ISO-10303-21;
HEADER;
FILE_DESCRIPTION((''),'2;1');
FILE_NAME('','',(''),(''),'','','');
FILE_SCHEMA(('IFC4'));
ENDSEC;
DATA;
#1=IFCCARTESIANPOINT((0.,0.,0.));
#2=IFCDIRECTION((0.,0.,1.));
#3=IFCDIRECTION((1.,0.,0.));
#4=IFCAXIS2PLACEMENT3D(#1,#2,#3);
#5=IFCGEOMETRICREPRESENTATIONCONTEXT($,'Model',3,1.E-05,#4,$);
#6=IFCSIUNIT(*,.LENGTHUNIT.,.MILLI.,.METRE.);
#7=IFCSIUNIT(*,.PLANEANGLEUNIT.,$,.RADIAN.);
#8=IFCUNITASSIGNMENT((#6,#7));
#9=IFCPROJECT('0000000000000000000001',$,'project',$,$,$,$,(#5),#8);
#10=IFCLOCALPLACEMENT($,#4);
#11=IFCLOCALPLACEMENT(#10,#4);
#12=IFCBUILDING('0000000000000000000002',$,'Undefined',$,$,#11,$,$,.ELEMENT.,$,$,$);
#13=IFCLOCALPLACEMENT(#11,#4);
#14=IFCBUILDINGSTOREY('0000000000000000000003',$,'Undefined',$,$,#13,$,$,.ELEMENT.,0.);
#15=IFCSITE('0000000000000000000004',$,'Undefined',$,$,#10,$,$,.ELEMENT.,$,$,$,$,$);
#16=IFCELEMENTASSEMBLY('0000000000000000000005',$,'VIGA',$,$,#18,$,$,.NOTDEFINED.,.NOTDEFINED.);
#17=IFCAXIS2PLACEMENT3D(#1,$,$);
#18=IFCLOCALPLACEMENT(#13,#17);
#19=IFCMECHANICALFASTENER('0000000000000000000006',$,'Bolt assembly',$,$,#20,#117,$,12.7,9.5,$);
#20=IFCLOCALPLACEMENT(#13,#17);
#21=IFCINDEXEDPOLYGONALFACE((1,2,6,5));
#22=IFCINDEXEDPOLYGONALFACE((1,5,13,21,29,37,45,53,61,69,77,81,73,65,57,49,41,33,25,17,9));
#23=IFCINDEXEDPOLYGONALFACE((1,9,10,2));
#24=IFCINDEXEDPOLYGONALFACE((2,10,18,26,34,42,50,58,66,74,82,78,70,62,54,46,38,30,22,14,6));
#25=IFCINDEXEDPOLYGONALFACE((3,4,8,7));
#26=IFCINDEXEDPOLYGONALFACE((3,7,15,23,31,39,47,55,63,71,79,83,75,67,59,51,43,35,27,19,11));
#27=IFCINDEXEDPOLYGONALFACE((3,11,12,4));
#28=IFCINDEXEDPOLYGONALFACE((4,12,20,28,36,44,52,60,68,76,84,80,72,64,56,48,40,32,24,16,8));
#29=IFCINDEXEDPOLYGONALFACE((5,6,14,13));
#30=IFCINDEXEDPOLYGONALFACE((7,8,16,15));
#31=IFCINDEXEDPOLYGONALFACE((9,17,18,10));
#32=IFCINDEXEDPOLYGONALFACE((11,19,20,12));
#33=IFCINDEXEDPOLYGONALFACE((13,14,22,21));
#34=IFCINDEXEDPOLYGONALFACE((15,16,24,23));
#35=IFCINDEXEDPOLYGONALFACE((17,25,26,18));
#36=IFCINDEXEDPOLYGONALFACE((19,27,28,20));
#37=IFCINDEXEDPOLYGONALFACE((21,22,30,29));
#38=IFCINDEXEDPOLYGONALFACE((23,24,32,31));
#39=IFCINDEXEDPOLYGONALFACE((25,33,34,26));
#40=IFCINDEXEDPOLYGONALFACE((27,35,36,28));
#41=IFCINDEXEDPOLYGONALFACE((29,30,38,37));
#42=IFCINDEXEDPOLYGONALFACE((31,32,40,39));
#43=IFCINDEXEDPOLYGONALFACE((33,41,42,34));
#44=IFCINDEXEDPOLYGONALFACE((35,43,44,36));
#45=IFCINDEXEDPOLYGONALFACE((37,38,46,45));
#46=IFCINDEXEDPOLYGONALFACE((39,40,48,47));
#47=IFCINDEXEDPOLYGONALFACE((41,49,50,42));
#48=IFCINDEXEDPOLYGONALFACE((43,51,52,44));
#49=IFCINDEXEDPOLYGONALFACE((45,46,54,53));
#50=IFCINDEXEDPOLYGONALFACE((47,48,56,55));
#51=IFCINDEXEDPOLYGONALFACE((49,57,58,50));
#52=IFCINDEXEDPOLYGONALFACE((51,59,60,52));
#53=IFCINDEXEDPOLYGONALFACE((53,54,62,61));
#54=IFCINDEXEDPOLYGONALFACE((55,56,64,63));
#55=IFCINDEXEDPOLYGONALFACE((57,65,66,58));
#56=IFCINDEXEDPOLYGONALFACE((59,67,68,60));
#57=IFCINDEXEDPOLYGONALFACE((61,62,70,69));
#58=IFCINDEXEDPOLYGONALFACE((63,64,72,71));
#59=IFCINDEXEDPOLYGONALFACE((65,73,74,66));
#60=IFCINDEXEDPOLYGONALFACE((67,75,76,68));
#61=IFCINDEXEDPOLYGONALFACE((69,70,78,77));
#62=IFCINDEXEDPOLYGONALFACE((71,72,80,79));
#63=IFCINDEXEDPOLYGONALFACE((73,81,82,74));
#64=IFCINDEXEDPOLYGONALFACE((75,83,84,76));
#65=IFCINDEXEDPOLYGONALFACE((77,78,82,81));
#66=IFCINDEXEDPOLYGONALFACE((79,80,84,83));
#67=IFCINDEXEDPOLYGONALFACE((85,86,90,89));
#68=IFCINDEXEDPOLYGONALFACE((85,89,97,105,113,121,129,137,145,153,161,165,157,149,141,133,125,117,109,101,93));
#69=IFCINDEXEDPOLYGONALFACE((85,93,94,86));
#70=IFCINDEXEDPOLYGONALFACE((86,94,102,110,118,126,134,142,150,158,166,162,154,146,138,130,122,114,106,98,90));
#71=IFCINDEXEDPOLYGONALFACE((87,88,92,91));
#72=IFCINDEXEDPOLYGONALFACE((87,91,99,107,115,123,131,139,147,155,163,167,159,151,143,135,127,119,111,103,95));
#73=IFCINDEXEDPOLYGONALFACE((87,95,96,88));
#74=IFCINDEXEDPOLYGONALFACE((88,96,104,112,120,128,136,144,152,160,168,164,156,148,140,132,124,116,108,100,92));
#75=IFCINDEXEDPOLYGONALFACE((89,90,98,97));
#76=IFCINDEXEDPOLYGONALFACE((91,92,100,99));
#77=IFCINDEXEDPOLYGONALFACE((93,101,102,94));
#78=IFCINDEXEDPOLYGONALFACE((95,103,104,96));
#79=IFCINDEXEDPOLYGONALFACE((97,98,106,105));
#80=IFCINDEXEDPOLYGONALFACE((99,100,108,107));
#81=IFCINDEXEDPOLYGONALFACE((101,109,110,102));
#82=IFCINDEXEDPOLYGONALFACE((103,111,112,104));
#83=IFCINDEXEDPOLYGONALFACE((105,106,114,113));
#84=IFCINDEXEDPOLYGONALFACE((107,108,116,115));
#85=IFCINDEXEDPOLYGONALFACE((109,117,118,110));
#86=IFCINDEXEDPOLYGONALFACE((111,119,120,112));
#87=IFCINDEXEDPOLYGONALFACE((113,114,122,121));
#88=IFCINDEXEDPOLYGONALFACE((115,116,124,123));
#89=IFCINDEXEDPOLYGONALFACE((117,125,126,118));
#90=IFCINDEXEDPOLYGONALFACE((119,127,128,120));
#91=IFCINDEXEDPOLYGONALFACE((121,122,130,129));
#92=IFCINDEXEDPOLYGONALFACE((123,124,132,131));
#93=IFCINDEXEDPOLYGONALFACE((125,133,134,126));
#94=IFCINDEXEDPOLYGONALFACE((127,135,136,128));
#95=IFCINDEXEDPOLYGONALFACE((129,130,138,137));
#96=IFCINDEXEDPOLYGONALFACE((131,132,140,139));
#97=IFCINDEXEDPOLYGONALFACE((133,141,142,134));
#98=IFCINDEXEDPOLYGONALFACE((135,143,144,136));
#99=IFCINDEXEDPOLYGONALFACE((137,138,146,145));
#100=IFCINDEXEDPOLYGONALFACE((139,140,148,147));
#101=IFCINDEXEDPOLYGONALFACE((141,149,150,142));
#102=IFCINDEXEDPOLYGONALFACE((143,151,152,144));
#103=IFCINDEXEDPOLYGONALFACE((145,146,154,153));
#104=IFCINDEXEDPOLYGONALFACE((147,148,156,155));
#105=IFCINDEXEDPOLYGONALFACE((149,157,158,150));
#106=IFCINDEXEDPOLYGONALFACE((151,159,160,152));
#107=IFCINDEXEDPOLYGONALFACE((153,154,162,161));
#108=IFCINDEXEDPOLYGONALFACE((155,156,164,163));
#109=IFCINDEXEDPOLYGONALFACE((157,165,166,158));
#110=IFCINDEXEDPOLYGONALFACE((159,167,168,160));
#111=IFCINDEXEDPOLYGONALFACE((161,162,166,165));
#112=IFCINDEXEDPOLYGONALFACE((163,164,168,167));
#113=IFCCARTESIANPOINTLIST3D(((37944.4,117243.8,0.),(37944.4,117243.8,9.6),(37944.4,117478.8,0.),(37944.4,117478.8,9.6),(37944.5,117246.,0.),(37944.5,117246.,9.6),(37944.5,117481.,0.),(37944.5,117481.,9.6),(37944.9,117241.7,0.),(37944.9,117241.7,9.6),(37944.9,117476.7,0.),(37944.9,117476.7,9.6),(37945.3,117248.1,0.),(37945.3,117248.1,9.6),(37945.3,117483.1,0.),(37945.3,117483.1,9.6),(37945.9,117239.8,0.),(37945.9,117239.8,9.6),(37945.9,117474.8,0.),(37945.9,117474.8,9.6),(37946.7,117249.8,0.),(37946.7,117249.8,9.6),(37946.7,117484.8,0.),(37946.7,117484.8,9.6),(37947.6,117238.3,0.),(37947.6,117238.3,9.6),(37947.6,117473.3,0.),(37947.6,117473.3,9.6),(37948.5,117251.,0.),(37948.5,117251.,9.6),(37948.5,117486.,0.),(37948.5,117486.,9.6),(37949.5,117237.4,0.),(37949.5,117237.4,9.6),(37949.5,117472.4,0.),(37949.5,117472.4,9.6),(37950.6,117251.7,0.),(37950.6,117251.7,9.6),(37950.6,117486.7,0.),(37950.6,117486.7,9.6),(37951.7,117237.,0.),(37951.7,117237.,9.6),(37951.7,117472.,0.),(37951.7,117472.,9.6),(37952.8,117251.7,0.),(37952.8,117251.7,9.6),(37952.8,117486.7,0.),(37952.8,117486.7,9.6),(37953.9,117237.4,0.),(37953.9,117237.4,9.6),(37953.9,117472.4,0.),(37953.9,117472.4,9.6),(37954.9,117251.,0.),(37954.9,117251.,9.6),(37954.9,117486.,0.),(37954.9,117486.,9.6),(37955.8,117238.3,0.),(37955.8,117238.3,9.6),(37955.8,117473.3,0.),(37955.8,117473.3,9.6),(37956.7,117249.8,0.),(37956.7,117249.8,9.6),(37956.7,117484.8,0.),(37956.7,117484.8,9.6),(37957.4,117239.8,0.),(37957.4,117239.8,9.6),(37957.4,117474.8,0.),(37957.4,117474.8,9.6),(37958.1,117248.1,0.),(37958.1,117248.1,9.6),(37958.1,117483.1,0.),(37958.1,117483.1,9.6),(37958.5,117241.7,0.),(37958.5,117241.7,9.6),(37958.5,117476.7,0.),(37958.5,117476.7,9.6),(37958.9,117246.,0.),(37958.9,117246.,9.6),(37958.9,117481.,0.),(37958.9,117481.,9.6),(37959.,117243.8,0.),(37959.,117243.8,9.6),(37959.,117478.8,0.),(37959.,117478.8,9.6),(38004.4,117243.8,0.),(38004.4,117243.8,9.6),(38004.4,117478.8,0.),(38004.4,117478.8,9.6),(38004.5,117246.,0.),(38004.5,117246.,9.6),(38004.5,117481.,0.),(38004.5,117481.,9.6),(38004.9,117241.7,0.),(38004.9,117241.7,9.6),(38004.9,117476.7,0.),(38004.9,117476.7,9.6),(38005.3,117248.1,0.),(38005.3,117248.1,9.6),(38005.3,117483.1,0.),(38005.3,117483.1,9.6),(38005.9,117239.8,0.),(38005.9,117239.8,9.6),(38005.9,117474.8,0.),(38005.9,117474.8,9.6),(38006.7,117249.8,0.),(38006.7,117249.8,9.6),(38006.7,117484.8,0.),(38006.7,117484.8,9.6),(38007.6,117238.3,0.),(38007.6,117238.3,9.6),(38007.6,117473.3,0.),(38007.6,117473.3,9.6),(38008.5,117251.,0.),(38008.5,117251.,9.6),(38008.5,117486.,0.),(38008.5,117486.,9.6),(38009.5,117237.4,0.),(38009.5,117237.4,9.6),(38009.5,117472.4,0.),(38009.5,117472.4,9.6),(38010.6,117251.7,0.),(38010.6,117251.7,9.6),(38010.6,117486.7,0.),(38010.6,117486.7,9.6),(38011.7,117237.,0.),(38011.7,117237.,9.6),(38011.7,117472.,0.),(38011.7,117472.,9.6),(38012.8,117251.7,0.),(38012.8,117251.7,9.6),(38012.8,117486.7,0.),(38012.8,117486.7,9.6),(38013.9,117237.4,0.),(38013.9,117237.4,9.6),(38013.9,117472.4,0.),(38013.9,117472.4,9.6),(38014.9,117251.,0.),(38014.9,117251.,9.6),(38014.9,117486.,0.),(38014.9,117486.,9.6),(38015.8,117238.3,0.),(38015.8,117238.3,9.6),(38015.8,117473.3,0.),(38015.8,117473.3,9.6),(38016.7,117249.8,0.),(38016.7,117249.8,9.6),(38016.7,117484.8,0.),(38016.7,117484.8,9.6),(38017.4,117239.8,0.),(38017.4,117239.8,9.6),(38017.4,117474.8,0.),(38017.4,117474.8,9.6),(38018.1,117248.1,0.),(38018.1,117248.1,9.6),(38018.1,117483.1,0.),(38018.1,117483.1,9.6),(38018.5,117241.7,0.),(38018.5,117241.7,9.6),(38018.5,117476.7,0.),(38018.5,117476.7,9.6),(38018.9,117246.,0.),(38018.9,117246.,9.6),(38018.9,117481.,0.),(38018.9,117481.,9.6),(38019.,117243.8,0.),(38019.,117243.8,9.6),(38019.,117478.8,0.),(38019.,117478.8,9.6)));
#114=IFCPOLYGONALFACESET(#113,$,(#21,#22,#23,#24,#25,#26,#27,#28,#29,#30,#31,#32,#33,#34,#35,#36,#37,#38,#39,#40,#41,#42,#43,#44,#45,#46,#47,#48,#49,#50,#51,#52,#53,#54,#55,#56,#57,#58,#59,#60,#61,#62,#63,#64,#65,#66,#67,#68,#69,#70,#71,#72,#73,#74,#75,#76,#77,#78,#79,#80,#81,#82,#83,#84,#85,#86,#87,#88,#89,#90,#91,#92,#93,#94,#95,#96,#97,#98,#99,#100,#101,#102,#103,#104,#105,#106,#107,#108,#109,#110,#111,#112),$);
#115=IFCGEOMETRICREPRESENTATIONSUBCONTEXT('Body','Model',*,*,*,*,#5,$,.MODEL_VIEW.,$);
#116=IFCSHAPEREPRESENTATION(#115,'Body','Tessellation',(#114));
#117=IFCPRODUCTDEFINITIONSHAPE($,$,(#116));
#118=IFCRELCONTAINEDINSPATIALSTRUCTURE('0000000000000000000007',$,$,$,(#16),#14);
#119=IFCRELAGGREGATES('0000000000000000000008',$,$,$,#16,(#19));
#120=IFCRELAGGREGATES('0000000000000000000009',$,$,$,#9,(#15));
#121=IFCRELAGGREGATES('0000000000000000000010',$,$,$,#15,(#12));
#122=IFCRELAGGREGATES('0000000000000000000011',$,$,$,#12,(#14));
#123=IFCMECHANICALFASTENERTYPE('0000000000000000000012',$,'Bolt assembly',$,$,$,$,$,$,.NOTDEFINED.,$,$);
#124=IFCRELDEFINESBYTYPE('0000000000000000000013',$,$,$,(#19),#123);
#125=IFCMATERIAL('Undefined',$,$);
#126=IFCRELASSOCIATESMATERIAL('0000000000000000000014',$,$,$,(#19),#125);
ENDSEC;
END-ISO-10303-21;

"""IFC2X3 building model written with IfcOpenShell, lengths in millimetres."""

from ifc_helpers import new_model, si_unit, frame, origin_with_axes, origin_2d_with_axis, place, context, subcontext, project, spatial, circle, extrude, source, transform, mapped, material, type_object, element, aggregate, save


model = new_model("IFC2X3")

# Units and contexts
model_context = context("Model", 3, precision=1e-05, world=origin_with_axes())
body_context = subcontext(model_context, "Body", "Model", "MODEL_VIEW")
ifc_project = project(units=[si_unit("LENGTHUNIT", "METRE", prefix="MILLI"), si_unit("PLANEANGLEUNIT", "RADIAN")], contexts=[model_context])

# Site, building, storey
site_placement = place(None, origin_with_axes())
site = spatial("IfcSite", under=ifc_project, at=site_placement, Name="Undefined", CompositionType="ELEMENT")
building_placement = place(site_placement, origin_with_axes())
building = spatial("IfcBuilding", under=site, at=building_placement, Name="Undefined", CompositionType="ELEMENT")
storey_placement = place(building_placement, origin_with_axes())
storey = spatial("IfcBuildingStorey", under=building, at=storey_placement, Name="Undefined", CompositionType="ELEMENT", Elevation=0.0)

# Element assembly
assembly_1_placement = place(storey_placement, origin_with_axes())
assembly_1 = element("IfcElementAssembly", 1, at=assembly_1_placement, inside=storey, Name="VIGA", AssemblyPlace="NOTDEFINED", PredefinedType="NOTDEFINED")

# Mechanical fastener
ifc_material_1 = material(Name="Undefined")
mechanical_fastener_type = type_object("IfcMechanicalFastenerType", Name="Bolt assembly")
shared_shape_1 = source(origin_with_axes(), body_context, "Body", "SweptSolid", [
    extrude(circle(Radius=7.3, at=origin_2d_with_axis()), frame((0.0, -9.5, 0.0), z_axis=(0.0, 1.0, 0.0), x_axis=(1.0, 0.0, 0.0)), (0.0, 0.0, 1.0), 9.6),
])
mechanical_fastener_1_placement = place(assembly_1_placement, frame((37981.7, 117479.4, 9.5), z_axis=(-1.0, 0.0, 0.0), x_axis=(0.0, -1.0, 0.0)))
mechanical_fastener_1 = element("IfcMechanicalFastener", 2, at=mechanical_fastener_1_placement, type_object=mechanical_fastener_type, material=ifc_material_1, Name="Bolt assembly", NominalDiameter=12.7, NominalLength=9.5, context=body_context, shape_type="MappedRepresentation", body=[
    mapped(shared_shape_1, transform((0.0, 0.0, 30.0))),
    mapped(shared_shape_1, transform((235.0, 0.0, 30.0))),
    mapped(shared_shape_1, transform((0.0, 0.0, -30.0))),
    mapped(shared_shape_1, transform((235.0, 0.0, -30.0))),
])
aggregate(assembly_1, [mechanical_fastener_1])

save(model, "model.ifc")
